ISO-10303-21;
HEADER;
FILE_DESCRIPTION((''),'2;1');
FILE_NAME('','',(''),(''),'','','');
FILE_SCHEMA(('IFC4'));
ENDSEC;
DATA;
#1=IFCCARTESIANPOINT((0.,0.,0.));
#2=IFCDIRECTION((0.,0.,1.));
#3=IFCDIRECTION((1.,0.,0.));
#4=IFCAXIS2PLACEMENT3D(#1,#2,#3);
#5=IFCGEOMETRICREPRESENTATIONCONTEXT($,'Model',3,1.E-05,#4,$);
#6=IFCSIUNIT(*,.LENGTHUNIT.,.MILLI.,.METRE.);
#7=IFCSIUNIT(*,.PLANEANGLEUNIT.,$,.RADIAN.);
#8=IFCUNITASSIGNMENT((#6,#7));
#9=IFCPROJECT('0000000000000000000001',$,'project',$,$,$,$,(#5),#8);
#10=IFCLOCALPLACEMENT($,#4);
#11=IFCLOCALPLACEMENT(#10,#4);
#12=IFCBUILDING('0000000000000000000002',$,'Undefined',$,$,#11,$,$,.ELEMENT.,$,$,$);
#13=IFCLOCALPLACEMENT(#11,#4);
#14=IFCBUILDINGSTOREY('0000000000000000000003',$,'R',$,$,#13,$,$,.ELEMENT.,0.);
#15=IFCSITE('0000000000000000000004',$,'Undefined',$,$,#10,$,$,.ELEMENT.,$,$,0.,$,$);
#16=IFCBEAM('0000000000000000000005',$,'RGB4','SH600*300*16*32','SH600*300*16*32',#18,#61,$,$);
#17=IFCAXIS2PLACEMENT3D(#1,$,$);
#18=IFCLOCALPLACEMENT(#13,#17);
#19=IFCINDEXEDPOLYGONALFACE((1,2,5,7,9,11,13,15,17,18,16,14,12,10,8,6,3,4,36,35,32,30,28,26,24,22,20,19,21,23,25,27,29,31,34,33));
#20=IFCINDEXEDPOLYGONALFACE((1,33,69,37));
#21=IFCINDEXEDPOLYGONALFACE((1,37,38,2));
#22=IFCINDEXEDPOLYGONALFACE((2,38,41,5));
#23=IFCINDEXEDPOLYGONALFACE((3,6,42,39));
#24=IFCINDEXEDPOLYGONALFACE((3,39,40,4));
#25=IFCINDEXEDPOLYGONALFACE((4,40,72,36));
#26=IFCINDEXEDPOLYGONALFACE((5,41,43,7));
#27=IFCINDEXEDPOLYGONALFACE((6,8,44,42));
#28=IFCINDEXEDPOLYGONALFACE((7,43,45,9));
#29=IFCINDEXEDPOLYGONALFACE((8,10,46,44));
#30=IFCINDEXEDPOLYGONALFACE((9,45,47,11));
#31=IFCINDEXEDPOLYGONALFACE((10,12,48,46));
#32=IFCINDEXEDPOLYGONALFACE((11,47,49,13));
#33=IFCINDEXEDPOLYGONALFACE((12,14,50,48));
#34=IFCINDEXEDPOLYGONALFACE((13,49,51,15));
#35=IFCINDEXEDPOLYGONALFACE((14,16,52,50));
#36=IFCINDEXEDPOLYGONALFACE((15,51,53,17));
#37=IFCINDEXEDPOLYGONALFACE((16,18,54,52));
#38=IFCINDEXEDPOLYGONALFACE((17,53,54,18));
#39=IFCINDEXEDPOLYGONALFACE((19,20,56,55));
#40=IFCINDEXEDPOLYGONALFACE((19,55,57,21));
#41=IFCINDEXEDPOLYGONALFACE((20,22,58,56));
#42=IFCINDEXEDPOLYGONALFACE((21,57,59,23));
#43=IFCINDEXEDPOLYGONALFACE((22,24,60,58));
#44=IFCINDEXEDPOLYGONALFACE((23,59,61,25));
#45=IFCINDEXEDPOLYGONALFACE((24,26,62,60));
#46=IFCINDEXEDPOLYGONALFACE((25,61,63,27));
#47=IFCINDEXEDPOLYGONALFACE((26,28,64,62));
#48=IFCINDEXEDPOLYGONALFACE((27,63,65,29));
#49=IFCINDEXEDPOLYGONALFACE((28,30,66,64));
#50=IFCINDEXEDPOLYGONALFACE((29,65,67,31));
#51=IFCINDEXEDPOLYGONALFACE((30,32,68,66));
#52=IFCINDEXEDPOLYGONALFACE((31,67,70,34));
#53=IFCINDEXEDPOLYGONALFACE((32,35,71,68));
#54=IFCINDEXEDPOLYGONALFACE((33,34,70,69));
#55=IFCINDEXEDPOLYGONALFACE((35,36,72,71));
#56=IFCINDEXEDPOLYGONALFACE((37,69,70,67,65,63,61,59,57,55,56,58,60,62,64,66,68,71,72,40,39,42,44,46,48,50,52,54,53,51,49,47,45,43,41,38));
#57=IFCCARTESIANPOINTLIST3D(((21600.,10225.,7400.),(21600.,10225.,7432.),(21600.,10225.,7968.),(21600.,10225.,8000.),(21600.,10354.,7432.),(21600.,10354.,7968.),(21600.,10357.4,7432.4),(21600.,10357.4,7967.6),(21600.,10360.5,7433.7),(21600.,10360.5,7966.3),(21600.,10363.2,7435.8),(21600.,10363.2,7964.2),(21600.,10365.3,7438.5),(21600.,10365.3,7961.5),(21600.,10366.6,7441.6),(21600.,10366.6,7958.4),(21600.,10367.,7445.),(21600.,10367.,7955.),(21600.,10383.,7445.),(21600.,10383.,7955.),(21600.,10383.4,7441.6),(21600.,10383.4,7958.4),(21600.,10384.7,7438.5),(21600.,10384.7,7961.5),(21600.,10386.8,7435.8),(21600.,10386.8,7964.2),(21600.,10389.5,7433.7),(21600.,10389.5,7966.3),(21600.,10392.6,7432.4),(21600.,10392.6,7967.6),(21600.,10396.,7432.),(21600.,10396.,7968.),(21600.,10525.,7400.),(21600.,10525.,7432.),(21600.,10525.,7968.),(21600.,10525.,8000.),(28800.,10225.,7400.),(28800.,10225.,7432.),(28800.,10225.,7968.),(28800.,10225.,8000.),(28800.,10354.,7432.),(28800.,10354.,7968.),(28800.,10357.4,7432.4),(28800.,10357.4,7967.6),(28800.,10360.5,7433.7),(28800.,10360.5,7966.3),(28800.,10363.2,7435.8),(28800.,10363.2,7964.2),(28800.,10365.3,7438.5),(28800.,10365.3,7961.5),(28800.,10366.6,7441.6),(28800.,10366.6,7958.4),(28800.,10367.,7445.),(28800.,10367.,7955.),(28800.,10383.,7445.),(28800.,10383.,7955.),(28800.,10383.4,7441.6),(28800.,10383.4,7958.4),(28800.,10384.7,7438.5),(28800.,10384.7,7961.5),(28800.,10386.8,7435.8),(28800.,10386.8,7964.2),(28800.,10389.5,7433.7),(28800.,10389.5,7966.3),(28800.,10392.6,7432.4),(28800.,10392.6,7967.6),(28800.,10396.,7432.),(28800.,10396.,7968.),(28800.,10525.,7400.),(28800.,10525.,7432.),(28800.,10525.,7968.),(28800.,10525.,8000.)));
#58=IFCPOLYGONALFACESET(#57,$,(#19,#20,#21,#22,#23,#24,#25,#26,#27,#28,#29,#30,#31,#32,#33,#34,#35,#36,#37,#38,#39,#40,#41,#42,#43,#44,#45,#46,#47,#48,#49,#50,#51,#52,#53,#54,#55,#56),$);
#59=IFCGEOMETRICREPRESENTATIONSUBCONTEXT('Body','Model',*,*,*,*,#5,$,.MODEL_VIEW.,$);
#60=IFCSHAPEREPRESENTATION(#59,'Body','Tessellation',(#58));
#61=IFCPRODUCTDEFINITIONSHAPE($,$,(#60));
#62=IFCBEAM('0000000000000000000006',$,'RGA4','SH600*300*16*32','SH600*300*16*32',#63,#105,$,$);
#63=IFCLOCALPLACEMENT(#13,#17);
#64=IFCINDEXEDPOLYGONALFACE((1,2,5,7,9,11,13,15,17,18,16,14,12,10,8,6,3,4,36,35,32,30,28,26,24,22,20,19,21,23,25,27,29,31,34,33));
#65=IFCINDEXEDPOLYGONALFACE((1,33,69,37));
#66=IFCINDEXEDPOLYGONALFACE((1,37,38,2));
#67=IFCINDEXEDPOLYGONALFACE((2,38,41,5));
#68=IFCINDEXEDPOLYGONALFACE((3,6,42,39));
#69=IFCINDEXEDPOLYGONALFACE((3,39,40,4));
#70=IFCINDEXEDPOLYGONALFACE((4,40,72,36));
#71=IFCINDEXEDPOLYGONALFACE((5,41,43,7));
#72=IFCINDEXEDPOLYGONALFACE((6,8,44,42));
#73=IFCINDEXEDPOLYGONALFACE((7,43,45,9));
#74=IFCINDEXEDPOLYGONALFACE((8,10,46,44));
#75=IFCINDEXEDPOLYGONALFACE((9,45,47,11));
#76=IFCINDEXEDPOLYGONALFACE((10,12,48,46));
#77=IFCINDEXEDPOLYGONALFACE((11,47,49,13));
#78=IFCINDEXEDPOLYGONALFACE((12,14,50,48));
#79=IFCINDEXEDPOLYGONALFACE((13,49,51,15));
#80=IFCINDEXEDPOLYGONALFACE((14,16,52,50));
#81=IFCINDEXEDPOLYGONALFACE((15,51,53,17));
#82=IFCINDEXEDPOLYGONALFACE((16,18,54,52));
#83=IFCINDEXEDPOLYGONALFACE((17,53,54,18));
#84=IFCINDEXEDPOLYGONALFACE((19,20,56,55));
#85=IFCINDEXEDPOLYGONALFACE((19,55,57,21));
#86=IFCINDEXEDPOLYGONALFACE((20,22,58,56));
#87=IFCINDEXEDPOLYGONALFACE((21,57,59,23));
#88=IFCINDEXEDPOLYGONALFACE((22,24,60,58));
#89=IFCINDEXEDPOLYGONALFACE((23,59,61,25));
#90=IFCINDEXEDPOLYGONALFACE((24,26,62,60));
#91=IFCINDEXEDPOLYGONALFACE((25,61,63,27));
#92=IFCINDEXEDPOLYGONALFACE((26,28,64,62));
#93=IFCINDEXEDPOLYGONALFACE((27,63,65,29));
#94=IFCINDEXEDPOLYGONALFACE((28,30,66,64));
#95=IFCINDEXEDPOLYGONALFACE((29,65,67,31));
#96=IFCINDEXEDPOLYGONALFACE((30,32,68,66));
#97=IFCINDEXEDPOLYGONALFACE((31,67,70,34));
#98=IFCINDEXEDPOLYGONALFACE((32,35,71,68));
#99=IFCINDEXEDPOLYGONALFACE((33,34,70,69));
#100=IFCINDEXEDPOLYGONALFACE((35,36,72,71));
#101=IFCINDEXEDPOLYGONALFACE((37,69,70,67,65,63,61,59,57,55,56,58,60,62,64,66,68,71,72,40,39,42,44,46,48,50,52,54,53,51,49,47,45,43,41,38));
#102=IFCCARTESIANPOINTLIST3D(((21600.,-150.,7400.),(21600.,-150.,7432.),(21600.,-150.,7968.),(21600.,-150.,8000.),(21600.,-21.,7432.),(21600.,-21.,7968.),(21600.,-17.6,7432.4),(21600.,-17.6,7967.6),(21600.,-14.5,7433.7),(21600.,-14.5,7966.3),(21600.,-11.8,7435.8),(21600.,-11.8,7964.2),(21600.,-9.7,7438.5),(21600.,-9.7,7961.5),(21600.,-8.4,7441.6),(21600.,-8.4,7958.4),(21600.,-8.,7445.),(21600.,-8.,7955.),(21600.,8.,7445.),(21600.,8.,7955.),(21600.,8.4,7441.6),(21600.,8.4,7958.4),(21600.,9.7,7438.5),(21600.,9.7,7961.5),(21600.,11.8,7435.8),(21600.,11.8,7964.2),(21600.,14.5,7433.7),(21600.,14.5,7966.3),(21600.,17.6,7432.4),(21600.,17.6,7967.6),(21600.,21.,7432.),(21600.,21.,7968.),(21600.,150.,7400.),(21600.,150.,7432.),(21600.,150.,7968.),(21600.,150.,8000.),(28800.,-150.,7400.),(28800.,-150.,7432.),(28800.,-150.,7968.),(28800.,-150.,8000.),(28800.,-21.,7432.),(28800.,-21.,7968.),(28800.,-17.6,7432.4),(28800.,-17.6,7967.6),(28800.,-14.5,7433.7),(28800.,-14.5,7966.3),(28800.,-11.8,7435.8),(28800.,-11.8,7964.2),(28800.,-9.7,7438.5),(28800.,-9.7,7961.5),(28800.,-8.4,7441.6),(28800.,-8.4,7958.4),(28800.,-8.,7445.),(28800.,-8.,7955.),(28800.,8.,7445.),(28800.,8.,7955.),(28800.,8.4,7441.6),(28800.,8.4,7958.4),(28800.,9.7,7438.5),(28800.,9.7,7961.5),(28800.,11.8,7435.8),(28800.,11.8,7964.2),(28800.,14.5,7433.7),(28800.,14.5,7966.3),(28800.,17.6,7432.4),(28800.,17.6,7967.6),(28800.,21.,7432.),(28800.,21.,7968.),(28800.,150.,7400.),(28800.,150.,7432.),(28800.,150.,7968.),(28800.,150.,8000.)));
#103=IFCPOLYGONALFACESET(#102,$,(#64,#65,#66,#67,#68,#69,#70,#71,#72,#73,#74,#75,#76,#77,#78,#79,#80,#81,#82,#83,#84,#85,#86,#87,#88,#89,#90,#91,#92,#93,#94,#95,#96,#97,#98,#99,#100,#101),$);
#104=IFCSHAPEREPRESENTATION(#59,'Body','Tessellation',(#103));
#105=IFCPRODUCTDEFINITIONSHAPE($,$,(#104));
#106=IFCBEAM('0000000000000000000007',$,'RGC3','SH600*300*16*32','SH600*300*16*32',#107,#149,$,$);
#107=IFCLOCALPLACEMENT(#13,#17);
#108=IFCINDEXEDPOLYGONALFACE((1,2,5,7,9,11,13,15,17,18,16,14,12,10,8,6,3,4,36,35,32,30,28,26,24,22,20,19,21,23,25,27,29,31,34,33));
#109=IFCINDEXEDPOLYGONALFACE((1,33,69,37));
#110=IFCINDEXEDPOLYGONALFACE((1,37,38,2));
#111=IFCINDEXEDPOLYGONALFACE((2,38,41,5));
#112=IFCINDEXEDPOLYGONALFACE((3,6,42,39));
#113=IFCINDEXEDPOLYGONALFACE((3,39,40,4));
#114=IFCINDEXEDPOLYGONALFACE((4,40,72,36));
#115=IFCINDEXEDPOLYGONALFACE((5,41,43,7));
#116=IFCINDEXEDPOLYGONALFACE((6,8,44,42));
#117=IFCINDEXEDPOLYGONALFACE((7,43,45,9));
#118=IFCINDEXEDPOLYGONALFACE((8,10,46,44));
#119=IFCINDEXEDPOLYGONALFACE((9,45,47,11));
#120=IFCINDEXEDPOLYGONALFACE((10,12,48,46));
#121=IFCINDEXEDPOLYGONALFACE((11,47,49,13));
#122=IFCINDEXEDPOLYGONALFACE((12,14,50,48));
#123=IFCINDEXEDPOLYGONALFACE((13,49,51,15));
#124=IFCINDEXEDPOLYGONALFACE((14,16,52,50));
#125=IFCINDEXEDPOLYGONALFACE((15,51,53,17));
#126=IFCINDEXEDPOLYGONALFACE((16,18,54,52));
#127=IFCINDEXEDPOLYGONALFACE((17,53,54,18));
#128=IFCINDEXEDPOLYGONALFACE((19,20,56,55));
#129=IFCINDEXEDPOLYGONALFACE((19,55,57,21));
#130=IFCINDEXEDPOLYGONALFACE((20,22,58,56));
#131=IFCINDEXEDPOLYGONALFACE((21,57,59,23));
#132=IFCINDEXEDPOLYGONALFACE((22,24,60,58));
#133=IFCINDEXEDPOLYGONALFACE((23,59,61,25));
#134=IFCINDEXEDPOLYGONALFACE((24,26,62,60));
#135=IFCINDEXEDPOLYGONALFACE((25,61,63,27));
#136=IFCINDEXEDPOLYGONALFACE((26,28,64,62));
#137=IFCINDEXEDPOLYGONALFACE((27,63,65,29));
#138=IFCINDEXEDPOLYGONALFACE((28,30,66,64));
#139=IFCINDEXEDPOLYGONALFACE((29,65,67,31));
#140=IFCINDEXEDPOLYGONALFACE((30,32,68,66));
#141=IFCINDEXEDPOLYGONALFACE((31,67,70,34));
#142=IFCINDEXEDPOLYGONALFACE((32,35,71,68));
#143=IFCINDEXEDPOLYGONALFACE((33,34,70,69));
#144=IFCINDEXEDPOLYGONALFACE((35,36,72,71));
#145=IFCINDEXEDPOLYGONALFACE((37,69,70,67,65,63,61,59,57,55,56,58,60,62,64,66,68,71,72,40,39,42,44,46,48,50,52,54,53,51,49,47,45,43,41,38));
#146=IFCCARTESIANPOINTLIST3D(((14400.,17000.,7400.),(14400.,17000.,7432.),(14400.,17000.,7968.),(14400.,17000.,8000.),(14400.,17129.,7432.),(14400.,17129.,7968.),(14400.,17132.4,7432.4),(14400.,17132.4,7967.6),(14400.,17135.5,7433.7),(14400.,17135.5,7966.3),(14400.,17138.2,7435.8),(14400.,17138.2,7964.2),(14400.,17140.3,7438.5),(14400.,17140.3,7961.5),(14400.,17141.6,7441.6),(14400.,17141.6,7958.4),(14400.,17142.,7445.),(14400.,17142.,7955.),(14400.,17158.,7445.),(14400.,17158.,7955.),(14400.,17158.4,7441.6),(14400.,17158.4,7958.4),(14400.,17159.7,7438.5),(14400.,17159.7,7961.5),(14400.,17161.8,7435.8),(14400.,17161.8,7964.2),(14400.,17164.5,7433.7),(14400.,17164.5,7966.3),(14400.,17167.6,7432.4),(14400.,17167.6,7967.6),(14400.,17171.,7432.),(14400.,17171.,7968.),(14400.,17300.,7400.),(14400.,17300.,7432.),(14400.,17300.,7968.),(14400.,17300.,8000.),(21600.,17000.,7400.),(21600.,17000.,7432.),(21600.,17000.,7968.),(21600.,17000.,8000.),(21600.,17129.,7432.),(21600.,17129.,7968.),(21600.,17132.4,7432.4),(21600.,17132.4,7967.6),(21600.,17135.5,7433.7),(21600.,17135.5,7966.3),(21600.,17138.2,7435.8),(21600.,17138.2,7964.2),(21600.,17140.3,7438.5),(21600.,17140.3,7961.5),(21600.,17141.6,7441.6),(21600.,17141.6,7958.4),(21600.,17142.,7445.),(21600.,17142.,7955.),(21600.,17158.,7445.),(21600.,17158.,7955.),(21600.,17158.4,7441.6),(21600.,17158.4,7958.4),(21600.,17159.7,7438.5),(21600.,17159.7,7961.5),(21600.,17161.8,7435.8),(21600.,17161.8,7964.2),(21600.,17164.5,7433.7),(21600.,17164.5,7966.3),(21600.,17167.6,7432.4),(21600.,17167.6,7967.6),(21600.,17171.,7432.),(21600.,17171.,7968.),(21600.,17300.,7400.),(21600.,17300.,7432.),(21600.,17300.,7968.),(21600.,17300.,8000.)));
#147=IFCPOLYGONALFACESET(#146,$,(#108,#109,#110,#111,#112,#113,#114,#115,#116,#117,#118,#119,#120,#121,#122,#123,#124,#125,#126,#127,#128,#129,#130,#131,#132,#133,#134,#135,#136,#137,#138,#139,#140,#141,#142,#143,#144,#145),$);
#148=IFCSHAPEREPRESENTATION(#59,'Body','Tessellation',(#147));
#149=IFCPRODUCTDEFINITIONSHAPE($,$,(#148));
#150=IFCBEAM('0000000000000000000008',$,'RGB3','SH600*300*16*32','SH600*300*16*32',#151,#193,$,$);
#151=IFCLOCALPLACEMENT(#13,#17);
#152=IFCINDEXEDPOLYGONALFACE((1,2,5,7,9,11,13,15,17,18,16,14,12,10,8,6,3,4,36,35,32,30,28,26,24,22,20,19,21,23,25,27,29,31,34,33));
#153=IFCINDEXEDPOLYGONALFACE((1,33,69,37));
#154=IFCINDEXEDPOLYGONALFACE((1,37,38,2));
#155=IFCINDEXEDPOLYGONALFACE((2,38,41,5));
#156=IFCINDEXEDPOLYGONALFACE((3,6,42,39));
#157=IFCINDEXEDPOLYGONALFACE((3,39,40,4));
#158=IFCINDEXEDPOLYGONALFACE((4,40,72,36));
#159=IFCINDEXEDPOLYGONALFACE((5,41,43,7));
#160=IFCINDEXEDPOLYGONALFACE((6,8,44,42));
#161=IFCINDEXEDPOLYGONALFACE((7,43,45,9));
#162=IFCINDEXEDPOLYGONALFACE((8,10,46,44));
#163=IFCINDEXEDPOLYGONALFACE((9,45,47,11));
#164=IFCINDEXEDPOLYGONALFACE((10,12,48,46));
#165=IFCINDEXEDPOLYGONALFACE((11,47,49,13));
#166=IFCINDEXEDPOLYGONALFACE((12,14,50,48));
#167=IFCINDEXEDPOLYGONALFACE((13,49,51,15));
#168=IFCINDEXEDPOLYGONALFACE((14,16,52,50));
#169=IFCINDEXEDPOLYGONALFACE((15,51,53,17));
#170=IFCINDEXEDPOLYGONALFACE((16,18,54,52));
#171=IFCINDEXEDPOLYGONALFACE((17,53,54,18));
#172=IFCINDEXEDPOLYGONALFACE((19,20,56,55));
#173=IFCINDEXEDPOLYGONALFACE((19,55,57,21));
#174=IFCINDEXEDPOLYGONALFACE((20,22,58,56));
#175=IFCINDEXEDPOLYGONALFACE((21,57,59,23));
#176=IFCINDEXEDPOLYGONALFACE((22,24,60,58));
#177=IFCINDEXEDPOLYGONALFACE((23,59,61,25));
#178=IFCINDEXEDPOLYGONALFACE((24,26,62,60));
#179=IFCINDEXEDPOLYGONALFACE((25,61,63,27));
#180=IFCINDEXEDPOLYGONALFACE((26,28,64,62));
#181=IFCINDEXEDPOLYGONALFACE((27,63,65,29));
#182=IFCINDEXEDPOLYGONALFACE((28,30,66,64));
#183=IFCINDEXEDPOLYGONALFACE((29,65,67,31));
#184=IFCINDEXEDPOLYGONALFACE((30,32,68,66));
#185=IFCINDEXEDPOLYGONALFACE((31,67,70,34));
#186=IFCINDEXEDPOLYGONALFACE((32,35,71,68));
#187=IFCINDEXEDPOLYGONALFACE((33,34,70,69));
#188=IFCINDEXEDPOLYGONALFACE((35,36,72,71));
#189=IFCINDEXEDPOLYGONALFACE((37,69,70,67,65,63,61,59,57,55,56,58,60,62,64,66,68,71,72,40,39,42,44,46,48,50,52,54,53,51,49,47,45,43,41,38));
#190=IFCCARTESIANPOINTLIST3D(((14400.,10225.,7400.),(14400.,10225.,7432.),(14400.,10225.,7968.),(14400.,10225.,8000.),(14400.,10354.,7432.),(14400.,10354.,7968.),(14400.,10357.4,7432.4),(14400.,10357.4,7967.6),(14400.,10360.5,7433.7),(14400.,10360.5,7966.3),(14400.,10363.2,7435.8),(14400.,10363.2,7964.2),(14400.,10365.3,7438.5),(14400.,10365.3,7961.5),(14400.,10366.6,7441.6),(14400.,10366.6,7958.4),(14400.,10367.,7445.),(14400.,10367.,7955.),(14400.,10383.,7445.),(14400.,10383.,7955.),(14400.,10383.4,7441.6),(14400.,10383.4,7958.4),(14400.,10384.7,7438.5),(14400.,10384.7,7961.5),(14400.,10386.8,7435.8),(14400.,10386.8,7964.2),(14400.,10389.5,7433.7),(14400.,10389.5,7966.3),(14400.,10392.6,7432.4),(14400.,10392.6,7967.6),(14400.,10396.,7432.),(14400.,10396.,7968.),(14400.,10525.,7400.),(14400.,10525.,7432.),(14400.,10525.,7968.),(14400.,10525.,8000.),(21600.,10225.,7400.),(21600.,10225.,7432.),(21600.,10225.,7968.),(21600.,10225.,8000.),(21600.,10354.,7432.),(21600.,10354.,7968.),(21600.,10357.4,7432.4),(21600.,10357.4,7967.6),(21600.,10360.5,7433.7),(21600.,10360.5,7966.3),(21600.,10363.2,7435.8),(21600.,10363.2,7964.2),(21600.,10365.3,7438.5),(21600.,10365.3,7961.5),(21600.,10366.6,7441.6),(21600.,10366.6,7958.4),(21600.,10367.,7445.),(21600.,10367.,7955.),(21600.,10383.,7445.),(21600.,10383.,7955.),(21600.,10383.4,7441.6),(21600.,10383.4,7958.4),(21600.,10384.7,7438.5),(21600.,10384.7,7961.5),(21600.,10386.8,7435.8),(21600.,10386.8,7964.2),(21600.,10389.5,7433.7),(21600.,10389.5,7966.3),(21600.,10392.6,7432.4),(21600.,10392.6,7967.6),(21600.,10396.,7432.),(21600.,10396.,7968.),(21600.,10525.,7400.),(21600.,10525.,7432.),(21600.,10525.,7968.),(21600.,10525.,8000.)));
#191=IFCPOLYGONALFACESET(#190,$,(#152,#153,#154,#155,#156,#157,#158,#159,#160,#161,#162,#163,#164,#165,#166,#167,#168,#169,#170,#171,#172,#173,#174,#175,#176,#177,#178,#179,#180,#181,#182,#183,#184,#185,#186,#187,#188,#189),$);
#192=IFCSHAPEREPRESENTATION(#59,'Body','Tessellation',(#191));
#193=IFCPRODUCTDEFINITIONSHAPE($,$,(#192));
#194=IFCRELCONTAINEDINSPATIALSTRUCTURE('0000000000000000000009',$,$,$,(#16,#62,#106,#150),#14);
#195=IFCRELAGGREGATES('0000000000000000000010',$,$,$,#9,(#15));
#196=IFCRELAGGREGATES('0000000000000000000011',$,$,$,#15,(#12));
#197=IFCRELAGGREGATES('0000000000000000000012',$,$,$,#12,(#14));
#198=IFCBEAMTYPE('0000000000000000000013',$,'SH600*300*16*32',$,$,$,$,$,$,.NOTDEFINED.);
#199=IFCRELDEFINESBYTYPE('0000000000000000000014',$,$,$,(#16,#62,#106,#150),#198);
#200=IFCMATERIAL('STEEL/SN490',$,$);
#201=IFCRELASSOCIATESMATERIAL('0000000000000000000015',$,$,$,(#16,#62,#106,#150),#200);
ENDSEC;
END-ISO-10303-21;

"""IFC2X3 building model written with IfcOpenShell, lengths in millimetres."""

from ifc_helpers import new_model, si_unit, frame, origin_with_axes, origin_2d_with_axis, place, context, subcontext, project, spatial, i_section, extrude, material, type_object, element, save


model = new_model("IFC2X3")

# Units and contexts
model_context = context("Model", 3, precision=1e-05, world=origin_with_axes())
body_context = subcontext(model_context, "Body", "Model", "MODEL_VIEW")
ifc_project = project(units=[si_unit("LENGTHUNIT", "METRE", prefix="MILLI"), si_unit("PLANEANGLEUNIT", "RADIAN")], contexts=[model_context])

# Site, building, storey
site_placement = place(None, origin_with_axes())
site = spatial("IfcSite", under=ifc_project, at=site_placement, Name="Undefined", CompositionType="ELEMENT", RefElevation=0.0)
building_placement = place(site_placement, origin_with_axes())
building = spatial("IfcBuilding", under=site, at=building_placement, Name="Undefined", CompositionType="ELEMENT")
storey_placement = place(building_placement, origin_with_axes())
storey = spatial("IfcBuildingStorey", under=building, at=storey_placement, Name="R", CompositionType="ELEMENT", Elevation=0.0)

# Beams
ifc_material_1 = material(Name="STEEL/SN490")
beam_type_1 = type_object("IfcBeamType", Name="SH600*300*16*32", PredefinedType="NOTDEFINED")
for number, where, z_axis, x_axis, name in (
    (1, (21600.0, 10375.0, 7700.0), (0.0, 0.0, 1.0), (1.0, 0.0, 0.0), "RGB4"),
    (2, (21600.0, 0.0, 7700.0), (0.0, 0.0, 1.0), (1.0, 0.0, 0.0), "RGA4"),
    (3, (14400.0, 17150.0, 7700.0), (0.0, 0.0, 1.0), (1.0, 0.0, 0.0), "RGC3"),
    (4, (14400.0, 10375.0, 7700.0), (0.0, 0.0, 1.0), (1.0, 0.0, 0.0), "RGB3"),
):
    element("IfcBeam", number, at=place(storey_placement, frame(where, z_axis=z_axis, x_axis=x_axis)), inside=storey, type_object=beam_type_1, material=ifc_material_1, Name=name, Description="SH600*300*16*32", ObjectType="SH600*300*16*32", context=body_context, shape_type="SweptSolid", body=[
        extrude(i_section(OverallWidth=300.0, OverallDepth=600.0, WebThickness=16.0, FlangeThickness=32.0, FilletRadius=13.0, at=origin_2d_with_axis()), frame((7200.0, 0.0, 0.0), z_axis=(-1.0, 0.0, 0.0), x_axis=(0.0, -1.0, 0.0)), (0.0, 0.0, 1.0), 7200.0),
    ])

save(model, "model.ifc")
